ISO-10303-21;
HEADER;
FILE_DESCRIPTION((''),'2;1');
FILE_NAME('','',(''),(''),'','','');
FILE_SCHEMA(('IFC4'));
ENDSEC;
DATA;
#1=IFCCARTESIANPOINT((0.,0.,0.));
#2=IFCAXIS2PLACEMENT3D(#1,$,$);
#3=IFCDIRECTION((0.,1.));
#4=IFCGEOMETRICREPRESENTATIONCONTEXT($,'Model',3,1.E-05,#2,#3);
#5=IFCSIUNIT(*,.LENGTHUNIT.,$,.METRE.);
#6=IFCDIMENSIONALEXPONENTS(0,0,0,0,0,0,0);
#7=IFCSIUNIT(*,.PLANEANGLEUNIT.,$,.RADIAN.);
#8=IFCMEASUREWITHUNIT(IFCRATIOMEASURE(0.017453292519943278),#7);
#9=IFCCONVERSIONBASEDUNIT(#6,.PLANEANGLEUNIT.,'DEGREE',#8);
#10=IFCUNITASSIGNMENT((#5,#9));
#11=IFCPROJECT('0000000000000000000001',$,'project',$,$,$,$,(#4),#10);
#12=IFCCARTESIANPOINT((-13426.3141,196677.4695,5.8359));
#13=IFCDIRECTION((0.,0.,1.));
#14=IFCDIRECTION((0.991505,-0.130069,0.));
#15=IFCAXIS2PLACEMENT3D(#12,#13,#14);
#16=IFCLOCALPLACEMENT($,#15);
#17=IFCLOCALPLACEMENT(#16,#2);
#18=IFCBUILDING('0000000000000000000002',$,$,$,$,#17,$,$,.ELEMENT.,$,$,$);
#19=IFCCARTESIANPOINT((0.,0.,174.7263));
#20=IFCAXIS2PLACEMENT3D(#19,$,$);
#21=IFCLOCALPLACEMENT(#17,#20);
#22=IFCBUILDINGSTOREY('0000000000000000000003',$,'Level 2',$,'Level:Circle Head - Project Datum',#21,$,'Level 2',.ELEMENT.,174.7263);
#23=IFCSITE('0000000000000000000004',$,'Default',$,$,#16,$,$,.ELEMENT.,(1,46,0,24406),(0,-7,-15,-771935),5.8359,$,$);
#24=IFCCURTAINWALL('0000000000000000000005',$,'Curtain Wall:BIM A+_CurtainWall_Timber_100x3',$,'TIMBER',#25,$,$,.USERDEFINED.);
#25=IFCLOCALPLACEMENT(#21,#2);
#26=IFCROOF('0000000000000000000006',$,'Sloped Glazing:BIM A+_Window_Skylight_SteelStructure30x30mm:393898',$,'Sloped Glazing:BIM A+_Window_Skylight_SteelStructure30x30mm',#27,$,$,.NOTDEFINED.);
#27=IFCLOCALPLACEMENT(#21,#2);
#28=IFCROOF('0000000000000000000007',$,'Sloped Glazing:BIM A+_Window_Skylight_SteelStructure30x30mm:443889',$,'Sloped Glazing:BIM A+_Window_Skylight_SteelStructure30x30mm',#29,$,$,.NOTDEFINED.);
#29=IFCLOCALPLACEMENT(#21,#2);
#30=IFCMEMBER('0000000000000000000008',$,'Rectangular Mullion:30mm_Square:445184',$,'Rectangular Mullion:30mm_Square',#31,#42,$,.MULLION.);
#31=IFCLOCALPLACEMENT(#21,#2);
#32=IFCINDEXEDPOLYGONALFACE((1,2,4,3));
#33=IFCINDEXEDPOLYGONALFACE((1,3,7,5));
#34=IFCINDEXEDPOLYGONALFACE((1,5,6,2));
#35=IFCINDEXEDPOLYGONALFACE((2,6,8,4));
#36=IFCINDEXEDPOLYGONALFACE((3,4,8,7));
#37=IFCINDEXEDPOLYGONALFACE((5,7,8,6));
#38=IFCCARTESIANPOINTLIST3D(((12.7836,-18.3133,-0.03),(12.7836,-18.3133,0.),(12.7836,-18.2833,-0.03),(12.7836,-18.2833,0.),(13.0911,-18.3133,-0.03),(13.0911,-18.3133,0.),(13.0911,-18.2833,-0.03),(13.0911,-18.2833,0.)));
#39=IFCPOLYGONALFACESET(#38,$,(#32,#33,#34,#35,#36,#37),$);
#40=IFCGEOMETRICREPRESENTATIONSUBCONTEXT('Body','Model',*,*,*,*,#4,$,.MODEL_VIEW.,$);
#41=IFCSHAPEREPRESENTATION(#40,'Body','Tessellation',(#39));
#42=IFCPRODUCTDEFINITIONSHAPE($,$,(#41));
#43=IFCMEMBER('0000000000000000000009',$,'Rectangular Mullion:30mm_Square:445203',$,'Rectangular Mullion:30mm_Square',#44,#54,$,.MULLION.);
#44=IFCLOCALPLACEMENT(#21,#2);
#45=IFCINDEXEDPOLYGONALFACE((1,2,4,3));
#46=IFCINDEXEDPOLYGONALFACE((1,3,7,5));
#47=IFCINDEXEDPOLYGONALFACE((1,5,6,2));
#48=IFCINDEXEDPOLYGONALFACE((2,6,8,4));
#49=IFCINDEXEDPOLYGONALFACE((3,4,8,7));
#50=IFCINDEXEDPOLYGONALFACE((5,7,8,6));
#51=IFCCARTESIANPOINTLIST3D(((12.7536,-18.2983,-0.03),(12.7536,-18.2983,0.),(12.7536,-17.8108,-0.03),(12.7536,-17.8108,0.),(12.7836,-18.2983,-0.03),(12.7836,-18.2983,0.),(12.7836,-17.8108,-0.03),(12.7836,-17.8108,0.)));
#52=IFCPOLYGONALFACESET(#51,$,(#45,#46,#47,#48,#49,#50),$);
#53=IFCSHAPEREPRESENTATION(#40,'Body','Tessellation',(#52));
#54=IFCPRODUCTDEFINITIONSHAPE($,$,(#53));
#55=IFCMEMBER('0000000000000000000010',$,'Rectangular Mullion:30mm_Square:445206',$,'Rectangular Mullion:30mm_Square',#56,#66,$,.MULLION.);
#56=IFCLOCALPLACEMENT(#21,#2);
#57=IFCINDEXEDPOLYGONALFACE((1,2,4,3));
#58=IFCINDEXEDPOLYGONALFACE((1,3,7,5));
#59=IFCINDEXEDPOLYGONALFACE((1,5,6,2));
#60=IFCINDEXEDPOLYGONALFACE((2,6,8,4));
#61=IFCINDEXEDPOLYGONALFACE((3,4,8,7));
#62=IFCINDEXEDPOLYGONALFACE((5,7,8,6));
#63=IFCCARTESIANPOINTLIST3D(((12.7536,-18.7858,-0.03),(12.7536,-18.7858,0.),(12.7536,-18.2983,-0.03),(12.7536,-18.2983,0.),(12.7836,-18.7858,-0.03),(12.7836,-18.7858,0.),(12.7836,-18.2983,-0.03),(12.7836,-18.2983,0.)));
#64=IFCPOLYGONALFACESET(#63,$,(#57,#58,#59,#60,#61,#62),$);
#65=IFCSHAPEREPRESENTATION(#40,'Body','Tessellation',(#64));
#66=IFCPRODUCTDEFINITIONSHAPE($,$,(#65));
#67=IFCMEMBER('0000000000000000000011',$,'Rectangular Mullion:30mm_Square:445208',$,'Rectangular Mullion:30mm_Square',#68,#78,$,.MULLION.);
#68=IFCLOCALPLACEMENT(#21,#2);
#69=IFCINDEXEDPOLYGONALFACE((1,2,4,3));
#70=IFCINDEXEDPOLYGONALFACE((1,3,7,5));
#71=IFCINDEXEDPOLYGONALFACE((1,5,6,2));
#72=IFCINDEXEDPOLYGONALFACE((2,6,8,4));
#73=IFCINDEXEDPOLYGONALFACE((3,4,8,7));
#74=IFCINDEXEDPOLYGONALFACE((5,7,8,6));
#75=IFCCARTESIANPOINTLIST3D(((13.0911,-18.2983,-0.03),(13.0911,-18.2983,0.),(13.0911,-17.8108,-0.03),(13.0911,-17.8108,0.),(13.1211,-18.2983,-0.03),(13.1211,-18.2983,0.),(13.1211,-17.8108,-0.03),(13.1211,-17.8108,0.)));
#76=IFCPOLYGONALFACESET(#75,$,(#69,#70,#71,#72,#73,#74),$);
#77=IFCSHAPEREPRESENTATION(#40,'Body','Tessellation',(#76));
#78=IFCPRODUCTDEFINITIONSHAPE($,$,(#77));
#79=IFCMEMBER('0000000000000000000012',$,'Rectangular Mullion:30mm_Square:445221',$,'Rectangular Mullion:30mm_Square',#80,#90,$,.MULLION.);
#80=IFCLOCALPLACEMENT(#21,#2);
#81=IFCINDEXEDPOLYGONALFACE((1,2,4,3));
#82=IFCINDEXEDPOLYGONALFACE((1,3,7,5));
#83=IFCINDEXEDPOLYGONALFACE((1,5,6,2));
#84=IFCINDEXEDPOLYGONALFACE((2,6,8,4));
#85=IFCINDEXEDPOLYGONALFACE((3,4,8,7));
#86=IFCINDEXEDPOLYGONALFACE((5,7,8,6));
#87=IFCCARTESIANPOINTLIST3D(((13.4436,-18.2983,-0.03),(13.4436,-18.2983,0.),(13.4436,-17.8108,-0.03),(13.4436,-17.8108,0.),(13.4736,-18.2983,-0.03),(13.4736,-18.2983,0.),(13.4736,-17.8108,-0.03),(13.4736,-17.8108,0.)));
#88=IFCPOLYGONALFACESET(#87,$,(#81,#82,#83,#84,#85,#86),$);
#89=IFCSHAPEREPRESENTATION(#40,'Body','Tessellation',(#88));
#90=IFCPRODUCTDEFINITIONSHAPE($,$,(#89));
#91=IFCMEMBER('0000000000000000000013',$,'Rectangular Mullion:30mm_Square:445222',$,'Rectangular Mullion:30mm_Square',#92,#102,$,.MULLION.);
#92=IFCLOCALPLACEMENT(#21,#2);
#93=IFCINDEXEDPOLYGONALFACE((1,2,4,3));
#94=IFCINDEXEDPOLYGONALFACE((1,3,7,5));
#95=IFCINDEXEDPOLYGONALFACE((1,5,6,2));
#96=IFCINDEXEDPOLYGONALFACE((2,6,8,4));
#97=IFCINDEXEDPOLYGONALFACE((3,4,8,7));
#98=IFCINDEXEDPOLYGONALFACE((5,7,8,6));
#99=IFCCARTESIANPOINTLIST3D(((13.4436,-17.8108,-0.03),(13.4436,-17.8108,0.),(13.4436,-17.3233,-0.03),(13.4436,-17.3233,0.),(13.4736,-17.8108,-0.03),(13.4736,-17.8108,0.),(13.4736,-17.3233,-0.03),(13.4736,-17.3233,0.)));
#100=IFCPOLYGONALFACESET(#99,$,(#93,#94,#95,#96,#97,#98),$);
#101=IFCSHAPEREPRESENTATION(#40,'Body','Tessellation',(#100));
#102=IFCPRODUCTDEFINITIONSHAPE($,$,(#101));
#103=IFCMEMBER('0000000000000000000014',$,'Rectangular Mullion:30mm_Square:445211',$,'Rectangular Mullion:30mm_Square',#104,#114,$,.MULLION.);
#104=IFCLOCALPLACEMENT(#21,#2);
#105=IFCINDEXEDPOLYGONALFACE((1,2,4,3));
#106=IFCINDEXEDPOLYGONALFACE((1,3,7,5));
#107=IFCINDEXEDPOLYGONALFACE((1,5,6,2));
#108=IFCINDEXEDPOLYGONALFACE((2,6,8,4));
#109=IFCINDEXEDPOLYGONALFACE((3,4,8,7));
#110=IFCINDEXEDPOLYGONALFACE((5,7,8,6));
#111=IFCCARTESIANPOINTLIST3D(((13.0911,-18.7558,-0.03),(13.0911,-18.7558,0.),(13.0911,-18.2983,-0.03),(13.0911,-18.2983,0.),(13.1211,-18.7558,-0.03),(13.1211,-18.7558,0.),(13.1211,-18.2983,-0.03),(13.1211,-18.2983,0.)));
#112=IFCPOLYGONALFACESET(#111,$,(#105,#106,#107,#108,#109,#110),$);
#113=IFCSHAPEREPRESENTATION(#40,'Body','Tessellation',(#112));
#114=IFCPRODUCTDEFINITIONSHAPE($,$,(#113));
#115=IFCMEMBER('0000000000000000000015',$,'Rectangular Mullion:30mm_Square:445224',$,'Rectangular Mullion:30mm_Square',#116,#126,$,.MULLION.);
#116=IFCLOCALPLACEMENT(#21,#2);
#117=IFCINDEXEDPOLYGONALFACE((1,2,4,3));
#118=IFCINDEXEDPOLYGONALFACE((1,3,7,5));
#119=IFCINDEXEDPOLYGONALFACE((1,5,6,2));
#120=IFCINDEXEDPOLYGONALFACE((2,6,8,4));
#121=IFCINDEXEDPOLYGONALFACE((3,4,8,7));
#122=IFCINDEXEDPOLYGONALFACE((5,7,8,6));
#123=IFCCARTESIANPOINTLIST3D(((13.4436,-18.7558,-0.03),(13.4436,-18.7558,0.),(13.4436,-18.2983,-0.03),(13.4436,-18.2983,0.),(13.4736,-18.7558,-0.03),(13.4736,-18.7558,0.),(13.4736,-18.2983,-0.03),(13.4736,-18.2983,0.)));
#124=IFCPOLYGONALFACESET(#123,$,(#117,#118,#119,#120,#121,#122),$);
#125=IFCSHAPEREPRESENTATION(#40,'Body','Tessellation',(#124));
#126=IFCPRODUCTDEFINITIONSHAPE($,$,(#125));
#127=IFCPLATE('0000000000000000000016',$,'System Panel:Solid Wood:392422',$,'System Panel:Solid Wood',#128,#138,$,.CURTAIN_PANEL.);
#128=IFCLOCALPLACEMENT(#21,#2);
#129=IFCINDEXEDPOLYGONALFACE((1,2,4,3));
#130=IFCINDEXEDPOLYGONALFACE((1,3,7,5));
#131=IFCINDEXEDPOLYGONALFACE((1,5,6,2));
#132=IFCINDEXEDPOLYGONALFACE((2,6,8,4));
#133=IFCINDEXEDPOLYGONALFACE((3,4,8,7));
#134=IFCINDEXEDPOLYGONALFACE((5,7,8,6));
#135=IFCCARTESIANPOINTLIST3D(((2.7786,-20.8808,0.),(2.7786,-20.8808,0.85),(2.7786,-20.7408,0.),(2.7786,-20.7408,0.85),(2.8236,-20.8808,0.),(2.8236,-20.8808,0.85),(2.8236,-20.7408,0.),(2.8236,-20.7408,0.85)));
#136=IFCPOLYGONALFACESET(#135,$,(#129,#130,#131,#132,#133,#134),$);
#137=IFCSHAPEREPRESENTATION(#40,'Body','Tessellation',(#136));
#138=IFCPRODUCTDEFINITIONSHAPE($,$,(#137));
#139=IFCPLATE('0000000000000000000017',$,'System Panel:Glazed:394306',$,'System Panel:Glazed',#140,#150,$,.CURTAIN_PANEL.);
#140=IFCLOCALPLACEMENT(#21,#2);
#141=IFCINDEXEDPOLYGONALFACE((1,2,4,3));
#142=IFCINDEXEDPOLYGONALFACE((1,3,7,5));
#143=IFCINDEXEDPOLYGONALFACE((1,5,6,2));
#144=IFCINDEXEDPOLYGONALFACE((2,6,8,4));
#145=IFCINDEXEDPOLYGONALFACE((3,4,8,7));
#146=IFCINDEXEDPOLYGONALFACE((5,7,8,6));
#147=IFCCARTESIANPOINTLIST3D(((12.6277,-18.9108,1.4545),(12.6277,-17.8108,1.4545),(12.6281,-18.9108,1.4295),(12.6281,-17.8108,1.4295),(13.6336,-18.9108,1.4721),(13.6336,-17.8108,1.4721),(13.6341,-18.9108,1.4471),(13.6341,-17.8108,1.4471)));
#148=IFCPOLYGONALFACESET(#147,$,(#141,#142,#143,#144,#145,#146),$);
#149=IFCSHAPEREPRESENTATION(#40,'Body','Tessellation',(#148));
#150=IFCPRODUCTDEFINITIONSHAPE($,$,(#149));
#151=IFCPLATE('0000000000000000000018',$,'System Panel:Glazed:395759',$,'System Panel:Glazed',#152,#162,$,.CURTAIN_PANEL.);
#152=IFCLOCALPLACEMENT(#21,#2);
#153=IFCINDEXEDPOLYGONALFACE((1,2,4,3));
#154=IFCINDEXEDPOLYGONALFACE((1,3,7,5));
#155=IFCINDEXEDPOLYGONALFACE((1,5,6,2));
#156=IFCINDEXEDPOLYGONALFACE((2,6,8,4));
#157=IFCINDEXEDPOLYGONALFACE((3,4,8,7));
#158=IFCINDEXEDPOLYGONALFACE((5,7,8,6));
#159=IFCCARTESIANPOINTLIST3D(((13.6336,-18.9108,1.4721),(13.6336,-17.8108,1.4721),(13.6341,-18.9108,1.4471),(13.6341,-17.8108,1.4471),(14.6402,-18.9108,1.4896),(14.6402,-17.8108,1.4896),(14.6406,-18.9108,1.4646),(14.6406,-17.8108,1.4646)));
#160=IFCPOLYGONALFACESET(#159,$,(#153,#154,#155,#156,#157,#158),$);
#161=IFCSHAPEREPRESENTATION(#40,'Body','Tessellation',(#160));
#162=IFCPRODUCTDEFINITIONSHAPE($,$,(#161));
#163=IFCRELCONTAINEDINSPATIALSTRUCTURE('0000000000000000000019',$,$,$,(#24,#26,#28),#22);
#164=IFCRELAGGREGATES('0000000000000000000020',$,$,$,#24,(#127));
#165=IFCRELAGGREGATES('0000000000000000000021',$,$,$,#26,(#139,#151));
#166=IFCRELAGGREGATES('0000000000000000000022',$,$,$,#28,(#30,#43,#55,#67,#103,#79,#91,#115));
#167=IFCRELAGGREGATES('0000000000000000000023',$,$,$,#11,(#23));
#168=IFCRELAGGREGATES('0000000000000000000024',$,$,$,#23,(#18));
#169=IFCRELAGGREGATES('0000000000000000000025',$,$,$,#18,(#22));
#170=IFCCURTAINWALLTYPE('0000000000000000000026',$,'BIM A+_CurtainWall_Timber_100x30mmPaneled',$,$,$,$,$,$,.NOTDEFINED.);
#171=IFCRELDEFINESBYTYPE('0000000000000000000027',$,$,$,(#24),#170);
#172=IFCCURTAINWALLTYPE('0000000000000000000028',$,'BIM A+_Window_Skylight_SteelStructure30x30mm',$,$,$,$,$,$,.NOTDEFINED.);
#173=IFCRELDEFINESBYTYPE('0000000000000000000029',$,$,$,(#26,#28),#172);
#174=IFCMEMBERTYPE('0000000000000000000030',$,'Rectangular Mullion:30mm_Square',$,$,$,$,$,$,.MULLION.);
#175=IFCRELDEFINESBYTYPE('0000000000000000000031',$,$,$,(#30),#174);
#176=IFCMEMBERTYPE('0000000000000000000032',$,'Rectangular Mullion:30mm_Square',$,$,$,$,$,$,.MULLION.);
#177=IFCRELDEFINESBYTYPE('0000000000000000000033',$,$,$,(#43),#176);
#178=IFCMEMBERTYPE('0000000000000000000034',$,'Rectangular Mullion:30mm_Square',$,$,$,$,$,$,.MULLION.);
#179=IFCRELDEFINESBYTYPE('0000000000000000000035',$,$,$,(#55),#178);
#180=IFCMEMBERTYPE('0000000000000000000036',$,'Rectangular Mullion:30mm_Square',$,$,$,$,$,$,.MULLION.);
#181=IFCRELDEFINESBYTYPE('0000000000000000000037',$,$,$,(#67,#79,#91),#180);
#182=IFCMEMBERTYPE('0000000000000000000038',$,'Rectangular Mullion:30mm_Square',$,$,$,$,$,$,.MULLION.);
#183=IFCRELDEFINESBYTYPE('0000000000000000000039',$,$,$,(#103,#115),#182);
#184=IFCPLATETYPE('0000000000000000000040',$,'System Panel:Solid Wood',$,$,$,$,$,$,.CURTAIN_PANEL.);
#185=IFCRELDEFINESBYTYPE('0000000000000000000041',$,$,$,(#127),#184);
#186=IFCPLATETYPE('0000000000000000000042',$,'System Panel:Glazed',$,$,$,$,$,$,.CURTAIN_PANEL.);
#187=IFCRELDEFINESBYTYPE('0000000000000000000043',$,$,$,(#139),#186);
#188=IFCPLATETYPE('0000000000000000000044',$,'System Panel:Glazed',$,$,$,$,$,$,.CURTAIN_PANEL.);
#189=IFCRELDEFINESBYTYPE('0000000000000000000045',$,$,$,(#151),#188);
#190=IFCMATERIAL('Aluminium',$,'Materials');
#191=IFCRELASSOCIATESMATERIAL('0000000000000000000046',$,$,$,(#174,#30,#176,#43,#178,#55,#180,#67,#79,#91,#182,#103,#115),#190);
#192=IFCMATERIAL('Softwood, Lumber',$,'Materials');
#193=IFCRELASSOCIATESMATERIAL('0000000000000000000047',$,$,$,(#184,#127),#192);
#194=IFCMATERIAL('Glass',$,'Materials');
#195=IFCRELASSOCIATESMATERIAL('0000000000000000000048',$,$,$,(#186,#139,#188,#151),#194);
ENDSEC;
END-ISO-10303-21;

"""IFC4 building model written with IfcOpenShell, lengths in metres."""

from ifc_helpers import new_model, entity, si_unit, converted_unit, direction, frame, origin, place, context, subcontext, project, spatial, indexed_curve, outline, extrude, source, transform, mapped, material, type_object, type_shapes, element, aggregate, save


model = new_model("IFC4")

# Units and contexts
model_context = context("Model", 3, precision=1e-05, world=origin(), true_north=direction((0.0, 1.0)))
body_context = subcontext(model_context, "Body", "Model", "MODEL_VIEW")
ifc_project = project(units=[si_unit("LENGTHUNIT", "METRE"), converted_unit("PLANEANGLEUNIT", "DEGREE", entity("IfcRatioMeasure", 0.017453292519943278), si_unit("PLANEANGLEUNIT", "RADIAN"), dimensions=[0, 0, 0, 0, 0, 0, 0])], contexts=[model_context])

# Site, building, storey
site_placement = place(None, frame((-13426.3141, 196677.4695, 5.8359), z_axis=(0.0, 0.0, 1.0), x_axis=(0.991505, -0.130069, 0.0)))
site = spatial("IfcSite", under=ifc_project, at=site_placement, Name="Default", CompositionType="ELEMENT", RefLatitude=(1, 46, 0, 24406), RefLongitude=(0, -7, -15, -771935), RefElevation=5.8359)
building_placement = place(site_placement, origin())
building = spatial("IfcBuilding", under=site, at=building_placement, CompositionType="ELEMENT")
storey_placement = place(building_placement, frame((0.0, 0.0, 174.7263)))
storey = spatial("IfcBuildingStorey", under=building, at=storey_placement, Name="Level 2", ObjectType="Level:Circle Head - Project Datum", LongName="Level 2", CompositionType="ELEMENT", Elevation=174.7263)

# Curtain wall
curtain_wall_type_1 = type_object("IfcCurtainWallType", Name="BIM A+_CurtainWall_Timber_100x30mmPaneled", PredefinedType="NOTDEFINED")
curtain_wall_placement = place(storey_placement, frame((0.0, 0.0, -174.7263)))
curtain_wall = element("IfcCurtainWall", 1, at=curtain_wall_placement, inside=storey, type_object=curtain_wall_type_1, Name="Curtain Wall:BIM A+_CurtainWall_Timber_100x3", ObjectType="TIMBER", PredefinedType="USERDEFINED")
ifc_material_1 = material(Name="Softwood, Lumber", Category="Materials")

# Roofs, members
curtain_wall_type_2 = type_object("IfcCurtainWallType", Name="BIM A+_Window_Skylight_SteelStructure30x30mm", PredefinedType="NOTDEFINED")
roof_1_placement = place(storey_placement, frame((0.0, 0.0, -174.7263)))
roof_1 = element("IfcRoof", 2, at=roof_1_placement, inside=storey, type_object=curtain_wall_type_2, Name="Sloped Glazing:BIM A+_Window_Skylight_SteelStructure30x30mm:393898", ObjectType="Sloped Glazing:BIM A+_Window_Skylight_SteelStructure30x30mm", PredefinedType="NOTDEFINED")
ifc_material_2 = material(Name="Aluminium", Category="Materials")
roof_2_placement = place(storey_placement, frame((0.0, 0.0, -174.7263)))
roof_2 = element("IfcRoof", 3, at=roof_2_placement, inside=storey, type_object=curtain_wall_type_2, Name="Sloped Glazing:BIM A+_Window_Skylight_SteelStructure30x30mm:443889", ObjectType="Sloped Glazing:BIM A+_Window_Skylight_SteelStructure30x30mm", PredefinedType="NOTDEFINED")
member_type_1 = type_object("IfcMemberType", Name="Rectangular Mullion:30mm_Square", PredefinedType="MULLION", material=ifc_material_2)
shared_shape_1 = source(origin(), body_context, "Body", "SweptSolid", [
    extrude(outline(indexed_curve([(-0.015, -0.015), (0.015, -0.015), (0.015, 0.015), (-0.015, 0.015), (-0.015, -0.015)], self_intersect=False)), frame((0.0, 0.0, -0.3075), z_axis=(0.0, 0.0, 1.0), x_axis=(0.0, -1.0, 0.0)), (0.0, 0.0, 1.0), 0.3075),
])
type_shapes(member_type_1, [shared_shape_1])
member_1_placement = place(roof_2_placement, frame((13.0911, -18.2983, 174.7113), z_axis=(1.0, 0.0, 0.0), x_axis=(0.0, -1.0, 0.0)))
member_1 = element("IfcMember", 4, at=member_1_placement, type_object=member_type_1, material=ifc_material_2, Name="Rectangular Mullion:30mm_Square:445184", ObjectType="Rectangular Mullion:30mm_Square", PredefinedType="MULLION", context=body_context, shape_type="MappedRepresentation", body=[
    mapped(shared_shape_1, transform((0.0, 0.0, 0.0), scale=1.0)),
])
member_type_2 = type_object("IfcMemberType", Name="Rectangular Mullion:30mm_Square", PredefinedType="MULLION", material=ifc_material_2)
shared_shape_2 = source(origin(), body_context, "Body", "SweptSolid", [
    extrude(outline(indexed_curve([(-0.015, -0.015), (0.015, -0.015), (0.015, 0.015), (-0.015, 0.015), (-0.015, -0.015)], self_intersect=False)), frame((-0.015, 0.0, -0.4875), z_axis=(0.0, 0.0, 1.0), x_axis=(0.0, -1.0, 0.0)), (0.0, 0.0, 1.0), 0.4875),
])
type_shapes(member_type_2, [shared_shape_2])
member_2_placement = place(roof_2_placement, frame((12.7536, -18.2983, 174.7113), z_axis=(0.0, -1.0, 0.0), x_axis=(-1.0, 0.0, 0.0)))
member_2 = element("IfcMember", 5, at=member_2_placement, type_object=member_type_2, material=ifc_material_2, Name="Rectangular Mullion:30mm_Square:445203", ObjectType="Rectangular Mullion:30mm_Square", PredefinedType="MULLION", context=body_context, shape_type="MappedRepresentation", body=[
    mapped(shared_shape_2, transform((0.0, 0.0, 0.0), scale=1.0)),
])
member_type_3 = type_object("IfcMemberType", Name="Rectangular Mullion:30mm_Square", PredefinedType="MULLION", material=ifc_material_2)
shared_shape_3 = source(origin(), body_context, "Body", "SweptSolid", [
    extrude(outline(indexed_curve([(-0.015, -0.015), (0.015, -0.015), (0.015, 0.015), (-0.015, 0.015), (-0.015, -0.015)], self_intersect=False)), frame((-0.015, 0.0, -0.4875), z_axis=(0.0, 0.0, 1.0), x_axis=(0.0, -1.0, 0.0)), (0.0, 0.0, 1.0), 0.4875),
])
type_shapes(member_type_3, [shared_shape_3])
member_3_placement = place(roof_2_placement, frame((12.7536, -18.7858, 174.7113), z_axis=(0.0, -1.0, 0.0), x_axis=(-1.0, 0.0, 0.0)))
member_3 = element("IfcMember", 6, at=member_3_placement, type_object=member_type_3, material=ifc_material_2, Name="Rectangular Mullion:30mm_Square:445206", ObjectType="Rectangular Mullion:30mm_Square", PredefinedType="MULLION", context=body_context, shape_type="MappedRepresentation", body=[
    mapped(shared_shape_3, transform((0.0, 0.0, 0.0), scale=1.0)),
])
member_type_4 = type_object("IfcMemberType", Name="Rectangular Mullion:30mm_Square", PredefinedType="MULLION", material=ifc_material_2)
shared_shape_4 = source(origin(), body_context, "Body", "SweptSolid", [
    extrude(outline(indexed_curve([(-0.015, -0.015), (0.015, -0.015), (0.015, 0.015), (-0.015, 0.015), (-0.015, -0.015)], self_intersect=False)), frame((0.0, 0.0, -0.4875), z_axis=(0.0, 0.0, 1.0), x_axis=(0.0, -1.0, 0.0)), (0.0, 0.0, 1.0), 0.4875),
])
type_shapes(member_type_4, [shared_shape_4])
member_4_placement = place(roof_2_placement, frame((13.1061, -18.2983, 174.7113), z_axis=(0.0, -1.0, 0.0), x_axis=(-1.0, 0.0, 0.0)))
member_4 = element("IfcMember", 7, at=member_4_placement, type_object=member_type_4, material=ifc_material_2, Name="Rectangular Mullion:30mm_Square:445208", ObjectType="Rectangular Mullion:30mm_Square", PredefinedType="MULLION", context=body_context, shape_type="MappedRepresentation", body=[
    mapped(shared_shape_4, transform((0.0, 0.0, 0.0), scale=1.0)),
])
member_5_placement = place(roof_2_placement, frame((13.4586, -18.2983, 174.7113), z_axis=(0.0, -1.0, 0.0), x_axis=(-1.0, 0.0, 0.0)))
member_5 = element("IfcMember", 8, at=member_5_placement, type_object=member_type_4, material=ifc_material_2, Name="Rectangular Mullion:30mm_Square:445221", ObjectType="Rectangular Mullion:30mm_Square", PredefinedType="MULLION", context=body_context, shape_type="MappedRepresentation", body=[
    mapped(shared_shape_4, transform((0.0, 0.0, 0.0), scale=1.0)),
])
member_6_placement = place(roof_2_placement, frame((13.4586, -17.8108, 174.7113), z_axis=(0.0, -1.0, 0.0), x_axis=(-1.0, 0.0, 0.0)))
member_6 = element("IfcMember", 9, at=member_6_placement, type_object=member_type_4, material=ifc_material_2, Name="Rectangular Mullion:30mm_Square:445222", ObjectType="Rectangular Mullion:30mm_Square", PredefinedType="MULLION", context=body_context, shape_type="MappedRepresentation", body=[
    mapped(shared_shape_4, transform((0.0, 0.0, 0.0), scale=1.0)),
])
member_type_5 = type_object("IfcMemberType", Name="Rectangular Mullion:30mm_Square", PredefinedType="MULLION", material=ifc_material_2)
shared_shape_5 = source(origin(), body_context, "Body", "SweptSolid", [
    extrude(outline(indexed_curve([(-0.015, -0.015), (0.015, -0.015), (0.015, 0.015), (-0.015, 0.015), (-0.015, -0.015)], self_intersect=False)), frame((0.0, 0.0, -0.4575), z_axis=(0.0, 0.0, 1.0), x_axis=(0.0, -1.0, 0.0)), (0.0, 0.0, 1.0), 0.4575),
])
type_shapes(member_type_5, [shared_shape_5])
member_7_placement = place(roof_2_placement, frame((13.1061, -18.7558, 174.7113), z_axis=(0.0, -1.0, 0.0), x_axis=(-1.0, 0.0, 0.0)))
member_7 = element("IfcMember", 10, at=member_7_placement, type_object=member_type_5, material=ifc_material_2, Name="Rectangular Mullion:30mm_Square:445211", ObjectType="Rectangular Mullion:30mm_Square", PredefinedType="MULLION", context=body_context, shape_type="MappedRepresentation", body=[
    mapped(shared_shape_5, transform((0.0, 0.0, 0.0), scale=1.0)),
])
member_8_placement = place(roof_2_placement, frame((13.4586, -18.7558, 174.7113), z_axis=(0.0, -1.0, 0.0), x_axis=(-1.0, 0.0, 0.0)))
member_8 = element("IfcMember", 11, at=member_8_placement, type_object=member_type_5, material=ifc_material_2, Name="Rectangular Mullion:30mm_Square:445224", ObjectType="Rectangular Mullion:30mm_Square", PredefinedType="MULLION", context=body_context, shape_type="MappedRepresentation", body=[
    mapped(shared_shape_5, transform((0.0, 0.0, 0.0), scale=1.0)),
])

# Plates
plate_type_1 = type_object("IfcPlateType", Name="System Panel:Solid Wood", PredefinedType="CURTAIN_PANEL", material=ifc_material_1)
shared_shape_6 = source(origin(), body_context, "Body", "SweptSolid", [
    extrude(outline(indexed_curve([(-0.0225, -0.07), (0.0225, -0.07), (0.0225, 0.07), (-0.0225, 0.07), (-0.0225, -0.07)], self_intersect=False)), frame((0.0, 0.0075, 0.0), z_axis=(0.0, 0.0, 1.0), x_axis=(0.0, 1.0, 0.0)), (0.0, 0.0, 1.0), 0.85),
])
type_shapes(plate_type_1, [shared_shape_6])
plate_1_placement = place(curtain_wall_placement, frame((2.8086, -20.8108, 174.7263), z_axis=(0.0, 0.0, 1.0), x_axis=(0.0, 1.0, 0.0)))
plate_1 = element("IfcPlate", 12, at=plate_1_placement, type_object=plate_type_1, material=ifc_material_1, Name="System Panel:Solid Wood:392422", ObjectType="System Panel:Solid Wood", PredefinedType="CURTAIN_PANEL", context=body_context, shape_type="MappedRepresentation", body=[
    mapped(shared_shape_6, transform((0.0, 0.0, 0.0), scale=1.0)),
])
aggregate(curtain_wall, [plate_1])
ifc_material_3 = material(Name="Glass", Category="Materials")
plate_type_2 = type_object("IfcPlateType", Name="System Panel:Glazed", PredefinedType="CURTAIN_PANEL", material=ifc_material_3)
shared_shape_7 = source(origin(), body_context, "Body", "SweptSolid", [
    extrude(outline(indexed_curve([(-0.0125, -0.55), (0.0125, -0.55), (0.0125, 0.55), (-0.0125, 0.55), (-0.0125, -0.55)], self_intersect=False)), frame((0.0, 0.037, 0.0), z_axis=(0.0, 0.0, 1.0), x_axis=(0.0, 1.0, 0.0)), (0.0, 0.0, 1.0), 1.0061),
])
type_shapes(plate_type_2, [shared_shape_7])
plate_2_placement = place(roof_1_placement, frame((12.6286, -18.3608, 176.1313), z_axis=(0.999848, 0.0, 0.017452), x_axis=(0.0, 1.0, 0.0)))
plate_2 = element("IfcPlate", 13, at=plate_2_placement, type_object=plate_type_2, material=ifc_material_3, Name="System Panel:Glazed:394306", ObjectType="System Panel:Glazed", PredefinedType="CURTAIN_PANEL", context=body_context, shape_type="MappedRepresentation", body=[
    mapped(shared_shape_7, transform((0.0, 0.0, 0.0), scale=1.0)),
])
plate_type_3 = type_object("IfcPlateType", Name="System Panel:Glazed", PredefinedType="CURTAIN_PANEL", material=ifc_material_3)
shared_shape_8 = source(origin(), body_context, "Body", "SweptSolid", [
    extrude(outline(indexed_curve([(-0.0125, -0.55), (0.0125, -0.55), (0.0125, 0.55), (-0.0125, 0.55), (-0.0125, -0.55)], self_intersect=False)), frame((0.0, 0.037, 0.0), z_axis=(0.0, 0.0, 1.0), x_axis=(0.0, 1.0, 0.0)), (0.0, 0.0, 1.0), 1.0067),
])
type_shapes(plate_type_3, [shared_shape_8])
plate_3_placement = place(roof_1_placement, frame((13.6345, -18.3608, 176.1489), z_axis=(0.999848, 0.0, 0.017452), x_axis=(0.0, 1.0, 0.0)))
plate_3 = element("IfcPlate", 14, at=plate_3_placement, type_object=plate_type_3, material=ifc_material_3, Name="System Panel:Glazed:395759", ObjectType="System Panel:Glazed", PredefinedType="CURTAIN_PANEL", context=body_context, shape_type="MappedRepresentation", body=[
    mapped(shared_shape_8, transform((0.0, 0.0, 0.0), scale=1.0)),
])
aggregate(roof_1, [plate_2, plate_3])
aggregate(roof_2, [member_1, member_2, member_3, member_4, member_7, member_5, member_6, member_8])

save(model, "model.ifc")
